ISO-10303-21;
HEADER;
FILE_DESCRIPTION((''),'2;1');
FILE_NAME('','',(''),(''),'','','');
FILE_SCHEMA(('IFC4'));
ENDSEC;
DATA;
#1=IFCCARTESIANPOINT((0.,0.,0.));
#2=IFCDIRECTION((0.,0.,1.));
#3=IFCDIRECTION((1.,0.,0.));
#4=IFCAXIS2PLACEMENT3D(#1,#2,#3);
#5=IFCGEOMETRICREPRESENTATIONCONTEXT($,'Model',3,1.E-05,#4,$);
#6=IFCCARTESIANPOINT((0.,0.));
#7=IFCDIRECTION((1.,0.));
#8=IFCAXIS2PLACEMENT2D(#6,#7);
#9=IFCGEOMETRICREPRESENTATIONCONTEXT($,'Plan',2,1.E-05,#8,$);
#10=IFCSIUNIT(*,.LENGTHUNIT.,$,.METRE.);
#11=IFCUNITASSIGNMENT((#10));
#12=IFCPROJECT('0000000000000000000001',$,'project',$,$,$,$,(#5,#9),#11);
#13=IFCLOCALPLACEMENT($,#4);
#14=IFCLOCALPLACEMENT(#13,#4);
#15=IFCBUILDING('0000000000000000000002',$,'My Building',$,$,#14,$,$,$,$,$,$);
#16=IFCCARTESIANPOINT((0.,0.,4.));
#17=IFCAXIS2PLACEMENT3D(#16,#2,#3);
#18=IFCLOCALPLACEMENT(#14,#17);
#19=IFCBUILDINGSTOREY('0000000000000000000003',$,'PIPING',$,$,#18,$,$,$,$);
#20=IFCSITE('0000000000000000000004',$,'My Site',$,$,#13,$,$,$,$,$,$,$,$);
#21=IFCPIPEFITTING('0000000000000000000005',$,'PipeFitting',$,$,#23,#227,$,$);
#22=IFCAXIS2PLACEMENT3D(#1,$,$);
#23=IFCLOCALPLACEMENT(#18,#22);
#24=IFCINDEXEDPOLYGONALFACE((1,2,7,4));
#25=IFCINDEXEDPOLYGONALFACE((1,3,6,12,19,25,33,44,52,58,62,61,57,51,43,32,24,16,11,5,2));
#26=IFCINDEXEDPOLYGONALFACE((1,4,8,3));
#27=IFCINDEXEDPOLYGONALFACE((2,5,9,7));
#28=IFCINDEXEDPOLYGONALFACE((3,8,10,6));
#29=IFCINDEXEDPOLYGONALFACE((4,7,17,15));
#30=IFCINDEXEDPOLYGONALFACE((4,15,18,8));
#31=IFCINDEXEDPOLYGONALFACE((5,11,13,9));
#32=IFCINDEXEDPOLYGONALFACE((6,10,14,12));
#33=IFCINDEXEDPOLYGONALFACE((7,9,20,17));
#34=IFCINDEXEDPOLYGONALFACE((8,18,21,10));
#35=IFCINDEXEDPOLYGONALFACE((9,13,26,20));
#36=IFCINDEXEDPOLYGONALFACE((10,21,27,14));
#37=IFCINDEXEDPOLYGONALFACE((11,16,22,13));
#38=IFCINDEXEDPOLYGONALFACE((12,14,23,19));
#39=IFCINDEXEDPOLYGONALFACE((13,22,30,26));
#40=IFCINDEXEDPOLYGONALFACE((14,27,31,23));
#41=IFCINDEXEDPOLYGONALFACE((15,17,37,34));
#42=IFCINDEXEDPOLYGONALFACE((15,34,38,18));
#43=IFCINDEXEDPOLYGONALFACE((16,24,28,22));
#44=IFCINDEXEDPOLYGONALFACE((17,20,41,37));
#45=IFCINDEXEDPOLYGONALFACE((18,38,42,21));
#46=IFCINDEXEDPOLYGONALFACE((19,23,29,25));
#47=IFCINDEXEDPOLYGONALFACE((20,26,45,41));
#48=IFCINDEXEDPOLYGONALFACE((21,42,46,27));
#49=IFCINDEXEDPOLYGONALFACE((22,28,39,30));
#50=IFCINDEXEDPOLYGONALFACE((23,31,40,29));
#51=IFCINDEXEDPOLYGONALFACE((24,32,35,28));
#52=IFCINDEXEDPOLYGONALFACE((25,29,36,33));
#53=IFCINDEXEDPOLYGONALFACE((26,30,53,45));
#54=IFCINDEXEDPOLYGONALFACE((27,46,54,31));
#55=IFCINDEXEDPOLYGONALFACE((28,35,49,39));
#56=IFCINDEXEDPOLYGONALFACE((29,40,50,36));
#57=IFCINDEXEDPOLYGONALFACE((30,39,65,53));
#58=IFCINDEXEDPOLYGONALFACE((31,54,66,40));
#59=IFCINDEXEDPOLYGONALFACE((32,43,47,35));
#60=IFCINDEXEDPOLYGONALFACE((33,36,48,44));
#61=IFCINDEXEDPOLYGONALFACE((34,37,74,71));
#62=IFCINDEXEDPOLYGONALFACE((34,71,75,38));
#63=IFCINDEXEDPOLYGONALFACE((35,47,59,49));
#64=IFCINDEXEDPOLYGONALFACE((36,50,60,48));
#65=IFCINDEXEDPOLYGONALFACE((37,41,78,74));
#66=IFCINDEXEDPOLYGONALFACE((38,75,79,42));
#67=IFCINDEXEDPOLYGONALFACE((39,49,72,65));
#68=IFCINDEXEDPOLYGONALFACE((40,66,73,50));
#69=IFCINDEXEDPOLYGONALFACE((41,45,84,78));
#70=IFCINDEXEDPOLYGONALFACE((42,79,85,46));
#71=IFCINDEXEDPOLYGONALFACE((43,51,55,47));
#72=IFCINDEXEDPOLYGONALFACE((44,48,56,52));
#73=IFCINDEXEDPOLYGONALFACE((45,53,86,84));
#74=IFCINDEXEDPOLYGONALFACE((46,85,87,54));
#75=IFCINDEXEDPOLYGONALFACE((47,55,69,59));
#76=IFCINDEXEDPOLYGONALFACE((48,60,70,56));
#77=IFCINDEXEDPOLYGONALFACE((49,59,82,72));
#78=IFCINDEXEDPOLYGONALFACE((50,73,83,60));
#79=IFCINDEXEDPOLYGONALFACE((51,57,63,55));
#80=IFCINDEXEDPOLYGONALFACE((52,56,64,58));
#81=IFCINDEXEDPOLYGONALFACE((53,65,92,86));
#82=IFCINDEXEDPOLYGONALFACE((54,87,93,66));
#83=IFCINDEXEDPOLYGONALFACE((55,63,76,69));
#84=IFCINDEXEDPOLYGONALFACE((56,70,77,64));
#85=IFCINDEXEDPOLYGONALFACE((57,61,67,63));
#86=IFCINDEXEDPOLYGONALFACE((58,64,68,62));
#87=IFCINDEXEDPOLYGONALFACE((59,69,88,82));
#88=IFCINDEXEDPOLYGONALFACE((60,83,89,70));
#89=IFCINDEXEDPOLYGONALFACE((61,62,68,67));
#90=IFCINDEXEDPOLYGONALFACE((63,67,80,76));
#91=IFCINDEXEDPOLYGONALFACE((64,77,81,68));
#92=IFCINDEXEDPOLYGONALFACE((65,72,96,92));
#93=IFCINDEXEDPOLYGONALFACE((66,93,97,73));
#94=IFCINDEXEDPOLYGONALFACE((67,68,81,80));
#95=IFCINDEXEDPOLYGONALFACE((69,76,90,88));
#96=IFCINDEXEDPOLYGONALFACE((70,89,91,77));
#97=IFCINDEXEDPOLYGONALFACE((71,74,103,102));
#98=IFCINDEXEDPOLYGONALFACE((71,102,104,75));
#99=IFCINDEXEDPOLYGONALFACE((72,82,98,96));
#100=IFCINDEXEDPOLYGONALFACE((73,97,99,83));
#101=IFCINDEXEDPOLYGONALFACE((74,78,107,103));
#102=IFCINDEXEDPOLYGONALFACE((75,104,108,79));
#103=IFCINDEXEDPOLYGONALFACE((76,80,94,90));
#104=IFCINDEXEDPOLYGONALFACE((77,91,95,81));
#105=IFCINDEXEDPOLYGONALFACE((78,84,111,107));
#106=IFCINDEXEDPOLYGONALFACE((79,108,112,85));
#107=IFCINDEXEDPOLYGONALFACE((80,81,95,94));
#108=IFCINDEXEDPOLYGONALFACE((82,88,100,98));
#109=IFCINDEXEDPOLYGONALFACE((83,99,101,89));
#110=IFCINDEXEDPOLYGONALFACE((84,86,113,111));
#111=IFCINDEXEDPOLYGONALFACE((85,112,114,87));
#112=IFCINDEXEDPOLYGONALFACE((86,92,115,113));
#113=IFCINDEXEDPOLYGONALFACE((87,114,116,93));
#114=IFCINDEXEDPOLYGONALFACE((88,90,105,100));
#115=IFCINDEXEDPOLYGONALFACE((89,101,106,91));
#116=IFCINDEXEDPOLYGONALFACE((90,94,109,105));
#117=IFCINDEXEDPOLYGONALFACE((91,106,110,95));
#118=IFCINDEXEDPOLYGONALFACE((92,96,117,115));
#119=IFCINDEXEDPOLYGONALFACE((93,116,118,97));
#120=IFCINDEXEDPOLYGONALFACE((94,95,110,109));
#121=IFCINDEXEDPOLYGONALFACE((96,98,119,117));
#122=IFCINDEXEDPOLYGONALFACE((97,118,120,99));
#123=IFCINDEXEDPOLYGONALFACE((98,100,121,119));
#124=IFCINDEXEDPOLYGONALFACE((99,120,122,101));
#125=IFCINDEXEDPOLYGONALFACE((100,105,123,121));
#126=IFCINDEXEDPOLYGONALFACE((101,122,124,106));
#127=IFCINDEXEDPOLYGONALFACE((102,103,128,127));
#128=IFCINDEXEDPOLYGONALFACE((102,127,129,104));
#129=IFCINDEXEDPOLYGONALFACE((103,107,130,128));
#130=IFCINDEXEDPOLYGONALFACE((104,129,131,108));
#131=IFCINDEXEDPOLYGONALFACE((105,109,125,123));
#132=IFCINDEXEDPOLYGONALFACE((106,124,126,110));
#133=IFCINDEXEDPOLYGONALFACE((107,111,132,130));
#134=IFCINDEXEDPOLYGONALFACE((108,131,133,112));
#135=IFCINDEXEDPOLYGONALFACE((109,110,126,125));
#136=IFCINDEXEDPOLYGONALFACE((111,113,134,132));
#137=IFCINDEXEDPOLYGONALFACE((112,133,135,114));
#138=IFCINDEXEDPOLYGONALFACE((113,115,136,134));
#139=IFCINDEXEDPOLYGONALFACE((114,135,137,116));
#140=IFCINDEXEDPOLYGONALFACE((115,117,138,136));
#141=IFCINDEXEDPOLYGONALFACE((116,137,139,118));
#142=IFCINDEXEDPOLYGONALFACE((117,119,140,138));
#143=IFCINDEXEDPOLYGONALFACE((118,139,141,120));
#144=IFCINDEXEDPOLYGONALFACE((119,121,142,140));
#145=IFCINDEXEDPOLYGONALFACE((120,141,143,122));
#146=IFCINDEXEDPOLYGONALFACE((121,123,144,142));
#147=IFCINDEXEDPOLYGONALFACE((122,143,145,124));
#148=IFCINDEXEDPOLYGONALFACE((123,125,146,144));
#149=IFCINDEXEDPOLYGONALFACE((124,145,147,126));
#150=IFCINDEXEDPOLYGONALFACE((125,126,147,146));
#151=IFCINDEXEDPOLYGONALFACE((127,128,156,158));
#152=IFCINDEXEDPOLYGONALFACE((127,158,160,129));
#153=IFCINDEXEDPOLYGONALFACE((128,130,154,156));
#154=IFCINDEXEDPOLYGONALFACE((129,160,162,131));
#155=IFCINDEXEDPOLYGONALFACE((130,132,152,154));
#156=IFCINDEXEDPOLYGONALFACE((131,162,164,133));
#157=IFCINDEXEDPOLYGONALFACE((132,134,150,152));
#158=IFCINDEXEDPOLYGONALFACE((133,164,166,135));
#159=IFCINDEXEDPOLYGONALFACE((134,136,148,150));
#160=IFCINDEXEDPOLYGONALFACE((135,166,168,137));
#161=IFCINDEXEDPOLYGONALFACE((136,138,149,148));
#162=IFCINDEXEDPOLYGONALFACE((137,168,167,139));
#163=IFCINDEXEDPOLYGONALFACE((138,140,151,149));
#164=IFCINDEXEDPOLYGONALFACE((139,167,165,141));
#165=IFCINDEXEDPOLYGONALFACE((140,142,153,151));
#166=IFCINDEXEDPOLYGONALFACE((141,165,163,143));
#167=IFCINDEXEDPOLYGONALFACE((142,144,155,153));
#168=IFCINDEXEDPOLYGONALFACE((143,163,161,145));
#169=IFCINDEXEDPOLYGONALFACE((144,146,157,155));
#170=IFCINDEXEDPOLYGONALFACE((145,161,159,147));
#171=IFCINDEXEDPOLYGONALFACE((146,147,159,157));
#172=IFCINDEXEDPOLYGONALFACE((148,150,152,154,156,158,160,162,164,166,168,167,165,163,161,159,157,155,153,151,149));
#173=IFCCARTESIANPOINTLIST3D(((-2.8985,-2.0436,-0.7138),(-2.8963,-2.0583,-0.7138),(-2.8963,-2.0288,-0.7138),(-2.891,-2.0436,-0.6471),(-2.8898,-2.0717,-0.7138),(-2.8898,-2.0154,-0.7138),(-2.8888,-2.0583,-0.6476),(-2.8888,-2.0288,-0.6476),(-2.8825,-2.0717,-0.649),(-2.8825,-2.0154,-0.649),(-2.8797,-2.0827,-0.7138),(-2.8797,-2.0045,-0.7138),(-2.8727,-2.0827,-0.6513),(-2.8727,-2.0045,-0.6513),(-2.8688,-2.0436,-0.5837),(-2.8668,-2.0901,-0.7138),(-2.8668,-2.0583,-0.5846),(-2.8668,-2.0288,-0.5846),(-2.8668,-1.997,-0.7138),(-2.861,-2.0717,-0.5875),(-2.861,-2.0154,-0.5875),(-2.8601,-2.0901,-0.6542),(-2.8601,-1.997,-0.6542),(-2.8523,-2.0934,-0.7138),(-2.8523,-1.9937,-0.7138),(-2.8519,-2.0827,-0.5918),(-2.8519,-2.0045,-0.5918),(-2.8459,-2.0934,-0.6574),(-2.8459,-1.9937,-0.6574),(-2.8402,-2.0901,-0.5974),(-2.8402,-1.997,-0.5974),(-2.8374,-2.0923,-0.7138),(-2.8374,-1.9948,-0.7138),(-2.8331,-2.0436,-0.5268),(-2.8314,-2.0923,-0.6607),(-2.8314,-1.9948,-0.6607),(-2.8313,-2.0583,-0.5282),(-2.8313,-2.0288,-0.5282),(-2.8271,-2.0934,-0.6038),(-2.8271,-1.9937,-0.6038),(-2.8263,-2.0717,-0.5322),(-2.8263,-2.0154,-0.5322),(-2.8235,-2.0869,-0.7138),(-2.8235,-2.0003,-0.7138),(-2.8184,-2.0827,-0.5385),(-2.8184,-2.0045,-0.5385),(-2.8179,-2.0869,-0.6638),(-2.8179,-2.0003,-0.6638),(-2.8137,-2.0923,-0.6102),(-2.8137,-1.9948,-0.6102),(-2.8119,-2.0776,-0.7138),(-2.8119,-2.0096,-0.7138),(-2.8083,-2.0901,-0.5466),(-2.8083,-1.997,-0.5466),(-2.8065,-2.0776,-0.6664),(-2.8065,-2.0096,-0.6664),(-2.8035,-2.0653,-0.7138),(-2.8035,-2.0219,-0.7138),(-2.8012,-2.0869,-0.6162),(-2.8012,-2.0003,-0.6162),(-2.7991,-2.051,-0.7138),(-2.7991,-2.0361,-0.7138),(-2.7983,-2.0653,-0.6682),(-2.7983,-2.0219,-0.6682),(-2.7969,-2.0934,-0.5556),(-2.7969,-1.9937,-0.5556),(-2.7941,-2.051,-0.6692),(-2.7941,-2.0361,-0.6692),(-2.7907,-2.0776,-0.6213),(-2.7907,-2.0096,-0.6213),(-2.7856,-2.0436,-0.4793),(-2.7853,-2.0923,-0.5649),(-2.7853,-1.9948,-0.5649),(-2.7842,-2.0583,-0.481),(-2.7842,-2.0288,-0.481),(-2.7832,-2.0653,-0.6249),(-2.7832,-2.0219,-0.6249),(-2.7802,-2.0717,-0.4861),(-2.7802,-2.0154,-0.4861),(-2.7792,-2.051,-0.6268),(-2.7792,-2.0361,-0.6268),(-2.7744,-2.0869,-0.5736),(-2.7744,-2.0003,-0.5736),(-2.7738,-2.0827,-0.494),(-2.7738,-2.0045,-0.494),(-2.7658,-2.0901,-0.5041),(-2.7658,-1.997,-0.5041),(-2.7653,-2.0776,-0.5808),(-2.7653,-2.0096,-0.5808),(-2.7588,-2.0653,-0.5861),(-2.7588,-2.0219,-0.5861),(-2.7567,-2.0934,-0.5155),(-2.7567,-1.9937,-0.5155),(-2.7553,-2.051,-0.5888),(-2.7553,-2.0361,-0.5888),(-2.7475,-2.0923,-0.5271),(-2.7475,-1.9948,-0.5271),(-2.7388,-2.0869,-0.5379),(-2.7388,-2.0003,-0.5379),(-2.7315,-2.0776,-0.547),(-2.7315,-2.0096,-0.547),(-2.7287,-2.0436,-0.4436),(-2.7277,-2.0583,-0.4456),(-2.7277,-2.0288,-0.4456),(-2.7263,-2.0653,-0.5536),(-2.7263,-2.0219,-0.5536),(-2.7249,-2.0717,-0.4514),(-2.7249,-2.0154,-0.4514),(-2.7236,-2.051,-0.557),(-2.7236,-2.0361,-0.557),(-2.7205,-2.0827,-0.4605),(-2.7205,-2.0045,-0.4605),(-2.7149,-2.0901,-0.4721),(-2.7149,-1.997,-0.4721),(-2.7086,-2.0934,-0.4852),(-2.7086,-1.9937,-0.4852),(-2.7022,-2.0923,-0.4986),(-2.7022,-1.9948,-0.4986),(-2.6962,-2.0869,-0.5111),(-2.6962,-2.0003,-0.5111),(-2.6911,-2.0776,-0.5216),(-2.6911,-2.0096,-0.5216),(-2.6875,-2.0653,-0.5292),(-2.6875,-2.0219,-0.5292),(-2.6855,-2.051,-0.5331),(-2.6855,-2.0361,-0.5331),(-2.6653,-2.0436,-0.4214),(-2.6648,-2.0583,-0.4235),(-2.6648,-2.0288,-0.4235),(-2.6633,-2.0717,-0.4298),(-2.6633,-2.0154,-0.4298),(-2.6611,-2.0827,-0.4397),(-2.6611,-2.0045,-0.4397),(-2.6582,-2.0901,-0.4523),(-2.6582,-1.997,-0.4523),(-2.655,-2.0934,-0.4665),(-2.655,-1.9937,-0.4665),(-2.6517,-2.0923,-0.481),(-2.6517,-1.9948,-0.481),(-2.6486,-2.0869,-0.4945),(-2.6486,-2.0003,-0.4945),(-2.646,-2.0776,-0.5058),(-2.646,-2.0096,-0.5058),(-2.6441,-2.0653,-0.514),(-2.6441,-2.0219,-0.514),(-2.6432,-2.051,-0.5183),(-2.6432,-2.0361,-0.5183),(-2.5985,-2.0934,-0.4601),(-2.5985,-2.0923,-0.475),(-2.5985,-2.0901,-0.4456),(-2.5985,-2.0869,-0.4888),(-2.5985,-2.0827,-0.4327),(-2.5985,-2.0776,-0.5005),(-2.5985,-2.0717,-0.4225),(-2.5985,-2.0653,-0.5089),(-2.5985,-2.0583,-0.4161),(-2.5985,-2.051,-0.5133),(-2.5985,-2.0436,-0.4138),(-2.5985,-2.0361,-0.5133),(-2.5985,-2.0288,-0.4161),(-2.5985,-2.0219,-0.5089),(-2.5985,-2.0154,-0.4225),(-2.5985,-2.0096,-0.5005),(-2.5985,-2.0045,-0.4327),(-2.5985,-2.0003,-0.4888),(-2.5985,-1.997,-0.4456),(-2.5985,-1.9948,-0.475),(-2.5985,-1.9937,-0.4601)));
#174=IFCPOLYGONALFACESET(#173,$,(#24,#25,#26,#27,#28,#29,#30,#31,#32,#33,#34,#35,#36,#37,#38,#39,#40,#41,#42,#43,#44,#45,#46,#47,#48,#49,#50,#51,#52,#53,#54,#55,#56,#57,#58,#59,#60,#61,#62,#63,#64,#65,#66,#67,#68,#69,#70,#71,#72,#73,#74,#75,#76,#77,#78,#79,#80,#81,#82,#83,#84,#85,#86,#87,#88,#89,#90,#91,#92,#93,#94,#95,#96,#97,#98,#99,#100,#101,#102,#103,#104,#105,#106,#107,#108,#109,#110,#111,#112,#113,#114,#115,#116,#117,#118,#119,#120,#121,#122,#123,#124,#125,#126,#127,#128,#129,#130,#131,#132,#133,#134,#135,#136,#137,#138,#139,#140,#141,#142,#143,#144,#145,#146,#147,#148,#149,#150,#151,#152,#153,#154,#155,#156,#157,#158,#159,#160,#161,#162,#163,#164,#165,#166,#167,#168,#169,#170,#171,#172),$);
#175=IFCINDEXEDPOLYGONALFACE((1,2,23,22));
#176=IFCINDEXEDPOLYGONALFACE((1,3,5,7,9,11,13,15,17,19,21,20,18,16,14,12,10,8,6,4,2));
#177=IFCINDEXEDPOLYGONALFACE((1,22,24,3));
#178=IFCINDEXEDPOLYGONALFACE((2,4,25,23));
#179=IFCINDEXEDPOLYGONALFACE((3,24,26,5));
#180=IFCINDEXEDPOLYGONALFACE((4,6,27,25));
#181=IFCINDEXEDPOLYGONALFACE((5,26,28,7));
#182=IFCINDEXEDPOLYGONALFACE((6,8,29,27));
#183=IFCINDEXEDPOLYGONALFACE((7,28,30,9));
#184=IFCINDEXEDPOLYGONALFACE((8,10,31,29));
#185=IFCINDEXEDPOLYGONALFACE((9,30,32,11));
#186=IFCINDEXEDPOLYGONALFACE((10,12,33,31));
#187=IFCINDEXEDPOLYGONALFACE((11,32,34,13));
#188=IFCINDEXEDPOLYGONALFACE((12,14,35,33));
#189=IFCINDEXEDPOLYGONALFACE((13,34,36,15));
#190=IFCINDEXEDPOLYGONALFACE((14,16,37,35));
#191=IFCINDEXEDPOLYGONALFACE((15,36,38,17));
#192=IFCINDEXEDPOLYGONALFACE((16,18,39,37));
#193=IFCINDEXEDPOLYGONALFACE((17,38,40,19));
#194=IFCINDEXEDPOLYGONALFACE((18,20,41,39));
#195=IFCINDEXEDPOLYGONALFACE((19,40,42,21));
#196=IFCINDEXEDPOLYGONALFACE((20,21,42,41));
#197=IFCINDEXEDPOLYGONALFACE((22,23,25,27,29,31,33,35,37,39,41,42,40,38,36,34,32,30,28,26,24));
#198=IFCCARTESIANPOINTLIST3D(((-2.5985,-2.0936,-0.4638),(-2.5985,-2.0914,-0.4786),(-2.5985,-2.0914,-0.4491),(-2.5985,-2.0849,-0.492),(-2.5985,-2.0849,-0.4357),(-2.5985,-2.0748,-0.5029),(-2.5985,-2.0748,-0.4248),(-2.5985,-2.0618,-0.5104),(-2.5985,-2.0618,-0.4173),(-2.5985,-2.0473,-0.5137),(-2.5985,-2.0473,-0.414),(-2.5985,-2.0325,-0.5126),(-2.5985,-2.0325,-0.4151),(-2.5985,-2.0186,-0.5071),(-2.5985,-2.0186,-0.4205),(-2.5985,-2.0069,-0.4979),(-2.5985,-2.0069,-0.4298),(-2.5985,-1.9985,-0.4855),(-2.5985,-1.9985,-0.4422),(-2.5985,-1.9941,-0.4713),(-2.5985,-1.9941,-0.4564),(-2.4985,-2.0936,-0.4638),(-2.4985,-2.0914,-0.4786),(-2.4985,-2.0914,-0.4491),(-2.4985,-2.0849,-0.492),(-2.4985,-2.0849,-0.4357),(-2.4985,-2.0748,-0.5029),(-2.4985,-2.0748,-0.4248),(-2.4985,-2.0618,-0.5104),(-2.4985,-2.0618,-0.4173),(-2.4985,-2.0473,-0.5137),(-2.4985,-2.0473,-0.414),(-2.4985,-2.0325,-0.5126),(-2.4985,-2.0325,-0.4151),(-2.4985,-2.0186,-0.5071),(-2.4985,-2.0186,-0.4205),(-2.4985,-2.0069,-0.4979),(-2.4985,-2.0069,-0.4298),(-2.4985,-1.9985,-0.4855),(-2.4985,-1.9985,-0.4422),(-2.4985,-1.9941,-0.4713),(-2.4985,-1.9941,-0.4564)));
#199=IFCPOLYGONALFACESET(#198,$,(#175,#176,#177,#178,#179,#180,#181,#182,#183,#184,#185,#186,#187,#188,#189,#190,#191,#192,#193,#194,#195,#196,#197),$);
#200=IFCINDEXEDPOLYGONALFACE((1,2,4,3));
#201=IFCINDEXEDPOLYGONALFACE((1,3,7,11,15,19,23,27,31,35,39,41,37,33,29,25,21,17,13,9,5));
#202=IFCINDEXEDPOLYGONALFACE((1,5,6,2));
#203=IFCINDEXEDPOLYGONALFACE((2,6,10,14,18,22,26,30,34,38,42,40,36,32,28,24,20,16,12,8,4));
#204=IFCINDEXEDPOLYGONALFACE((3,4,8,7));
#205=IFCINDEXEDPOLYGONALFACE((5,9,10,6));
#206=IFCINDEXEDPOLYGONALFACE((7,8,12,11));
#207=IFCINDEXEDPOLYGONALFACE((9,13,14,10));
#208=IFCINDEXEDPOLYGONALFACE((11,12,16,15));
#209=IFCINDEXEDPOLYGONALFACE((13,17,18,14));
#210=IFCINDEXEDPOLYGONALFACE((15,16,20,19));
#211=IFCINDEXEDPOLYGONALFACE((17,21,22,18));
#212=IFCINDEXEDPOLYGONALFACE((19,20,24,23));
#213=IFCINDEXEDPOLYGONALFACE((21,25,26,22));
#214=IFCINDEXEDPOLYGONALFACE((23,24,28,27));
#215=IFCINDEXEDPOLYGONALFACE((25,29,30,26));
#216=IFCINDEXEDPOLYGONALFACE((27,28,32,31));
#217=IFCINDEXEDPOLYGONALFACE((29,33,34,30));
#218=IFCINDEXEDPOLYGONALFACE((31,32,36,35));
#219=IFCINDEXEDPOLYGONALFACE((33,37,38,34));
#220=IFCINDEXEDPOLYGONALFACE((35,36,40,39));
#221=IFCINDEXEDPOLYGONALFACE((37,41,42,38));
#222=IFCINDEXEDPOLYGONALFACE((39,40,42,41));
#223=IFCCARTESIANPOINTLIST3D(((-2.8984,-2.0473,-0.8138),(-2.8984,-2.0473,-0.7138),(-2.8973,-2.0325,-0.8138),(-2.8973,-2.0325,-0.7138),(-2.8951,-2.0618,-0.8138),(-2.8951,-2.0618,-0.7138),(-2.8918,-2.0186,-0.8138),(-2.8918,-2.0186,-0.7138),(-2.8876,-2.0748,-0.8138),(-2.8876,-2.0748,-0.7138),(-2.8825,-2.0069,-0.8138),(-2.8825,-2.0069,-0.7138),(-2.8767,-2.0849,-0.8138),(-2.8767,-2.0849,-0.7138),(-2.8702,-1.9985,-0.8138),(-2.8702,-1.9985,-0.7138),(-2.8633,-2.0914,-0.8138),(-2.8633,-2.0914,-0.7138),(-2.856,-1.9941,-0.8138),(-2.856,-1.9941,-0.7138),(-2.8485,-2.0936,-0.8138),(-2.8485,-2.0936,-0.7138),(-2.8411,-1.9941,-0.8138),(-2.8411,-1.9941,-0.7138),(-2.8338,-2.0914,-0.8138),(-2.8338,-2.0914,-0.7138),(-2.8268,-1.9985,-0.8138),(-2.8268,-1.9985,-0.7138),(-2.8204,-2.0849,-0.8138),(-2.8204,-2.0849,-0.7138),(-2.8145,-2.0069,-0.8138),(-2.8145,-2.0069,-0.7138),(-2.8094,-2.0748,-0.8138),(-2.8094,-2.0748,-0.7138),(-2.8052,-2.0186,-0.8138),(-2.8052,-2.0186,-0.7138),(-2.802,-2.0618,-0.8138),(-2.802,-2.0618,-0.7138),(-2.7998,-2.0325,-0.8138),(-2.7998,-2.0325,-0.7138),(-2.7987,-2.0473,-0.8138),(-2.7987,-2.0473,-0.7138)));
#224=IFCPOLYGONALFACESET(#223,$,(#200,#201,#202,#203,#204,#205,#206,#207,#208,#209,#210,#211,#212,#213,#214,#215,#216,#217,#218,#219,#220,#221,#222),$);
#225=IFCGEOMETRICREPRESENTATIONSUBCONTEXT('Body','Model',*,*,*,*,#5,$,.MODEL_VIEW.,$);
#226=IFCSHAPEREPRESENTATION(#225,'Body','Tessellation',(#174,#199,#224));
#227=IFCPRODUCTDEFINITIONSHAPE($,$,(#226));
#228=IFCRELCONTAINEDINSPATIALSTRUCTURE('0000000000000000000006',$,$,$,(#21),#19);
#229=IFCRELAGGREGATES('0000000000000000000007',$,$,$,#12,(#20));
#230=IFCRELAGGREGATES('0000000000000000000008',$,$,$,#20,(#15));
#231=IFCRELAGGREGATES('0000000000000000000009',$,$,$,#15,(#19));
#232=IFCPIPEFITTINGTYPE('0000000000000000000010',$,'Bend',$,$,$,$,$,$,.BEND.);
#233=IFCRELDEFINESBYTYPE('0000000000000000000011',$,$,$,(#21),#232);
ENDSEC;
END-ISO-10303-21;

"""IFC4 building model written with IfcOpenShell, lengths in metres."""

from ifc_helpers import new_model, entity, si_unit, frame, origin_with_axes, origin_2d_with_axis, place, context, subcontext, project, spatial, circle, extrude, source, transform, mapped, type_object, type_shapes, element, save


model = new_model("IFC4")

# Units and contexts
model_context = context("Model", 3, precision=1e-05, world=origin_with_axes())
plan_context = context("Plan", 2, precision=1e-05, world=origin_2d_with_axis())
body_context = subcontext(model_context, "Body", "Model", "MODEL_VIEW")
ifc_project = project(units=[si_unit("LENGTHUNIT", "METRE")], contexts=[model_context, plan_context])

# Site, building, storey
site_placement = place(None, origin_with_axes())
site = spatial("IfcSite", under=ifc_project, at=site_placement, Name="My Site")
building_placement = place(site_placement, origin_with_axes())
building = spatial("IfcBuilding", under=site, at=building_placement, Name="My Building")
storey_placement = place(building_placement, frame((0.0, 0.0, 4.0), z_axis=(0.0, 0.0, 1.0), x_axis=(1.0, 0.0, 0.0)))
storey = spatial("IfcBuildingStorey", under=building, at=storey_placement, Name="PIPING")

# Pipe fitting
pipe_fitting_type = type_object("IfcPipeFittingType", Name="Bend", PredefinedType="BEND")
shared_shape = source(origin_with_axes(), body_context, "Body", "SolidModel", [
    entity("IfcSweptDiskSolid", entity("IfcIndexedPolyCurve", entity("IfcCartesianPointList3D", [[0.0, 0.0, 0.1], [0.0, -0.0732, 0.2768], [0.0, -0.25, 0.35]]), [entity("IfcArcIndex", [1, 2, 3])]), 0.05),
    extrude(circle(Radius=0.05), origin_with_axes(), (0.0, 0.0, 1.0), 0.1),
    extrude(circle(Radius=0.05), frame((0.0, -0.25, 0.35), z_axis=(0.0, -1.0, 0.0), x_axis=(1.0, 0.0, 0.0)), (0.0, 0.0, 1.0), 0.1),
])
type_shapes(pipe_fitting_type, [shared_shape])
for number, where, z_axis, x_axis, name in (
    (1, (-2.4985, -2.0436, -0.4638), (-1.0, 0.0, 0.0), (0.0, -1.0, 0.0), "PipeFitting"),
):
    element("IfcPipeFitting", number, at=place(storey_placement, frame(where, z_axis=z_axis, x_axis=x_axis)), inside=storey, type_object=pipe_fitting_type, Name=name, context=body_context, shape_type="MappedRepresentation", body=[
        mapped(shared_shape, transform((0.0, 0.0, 0.0), x_axis=(1.0, 0.0, 0.0), y_axis=(0.0, 1.0, 0.0), z_axis=(0.0, 0.0, 1.0), scale=1.0)),
    ])

save(model, "model.ifc")
